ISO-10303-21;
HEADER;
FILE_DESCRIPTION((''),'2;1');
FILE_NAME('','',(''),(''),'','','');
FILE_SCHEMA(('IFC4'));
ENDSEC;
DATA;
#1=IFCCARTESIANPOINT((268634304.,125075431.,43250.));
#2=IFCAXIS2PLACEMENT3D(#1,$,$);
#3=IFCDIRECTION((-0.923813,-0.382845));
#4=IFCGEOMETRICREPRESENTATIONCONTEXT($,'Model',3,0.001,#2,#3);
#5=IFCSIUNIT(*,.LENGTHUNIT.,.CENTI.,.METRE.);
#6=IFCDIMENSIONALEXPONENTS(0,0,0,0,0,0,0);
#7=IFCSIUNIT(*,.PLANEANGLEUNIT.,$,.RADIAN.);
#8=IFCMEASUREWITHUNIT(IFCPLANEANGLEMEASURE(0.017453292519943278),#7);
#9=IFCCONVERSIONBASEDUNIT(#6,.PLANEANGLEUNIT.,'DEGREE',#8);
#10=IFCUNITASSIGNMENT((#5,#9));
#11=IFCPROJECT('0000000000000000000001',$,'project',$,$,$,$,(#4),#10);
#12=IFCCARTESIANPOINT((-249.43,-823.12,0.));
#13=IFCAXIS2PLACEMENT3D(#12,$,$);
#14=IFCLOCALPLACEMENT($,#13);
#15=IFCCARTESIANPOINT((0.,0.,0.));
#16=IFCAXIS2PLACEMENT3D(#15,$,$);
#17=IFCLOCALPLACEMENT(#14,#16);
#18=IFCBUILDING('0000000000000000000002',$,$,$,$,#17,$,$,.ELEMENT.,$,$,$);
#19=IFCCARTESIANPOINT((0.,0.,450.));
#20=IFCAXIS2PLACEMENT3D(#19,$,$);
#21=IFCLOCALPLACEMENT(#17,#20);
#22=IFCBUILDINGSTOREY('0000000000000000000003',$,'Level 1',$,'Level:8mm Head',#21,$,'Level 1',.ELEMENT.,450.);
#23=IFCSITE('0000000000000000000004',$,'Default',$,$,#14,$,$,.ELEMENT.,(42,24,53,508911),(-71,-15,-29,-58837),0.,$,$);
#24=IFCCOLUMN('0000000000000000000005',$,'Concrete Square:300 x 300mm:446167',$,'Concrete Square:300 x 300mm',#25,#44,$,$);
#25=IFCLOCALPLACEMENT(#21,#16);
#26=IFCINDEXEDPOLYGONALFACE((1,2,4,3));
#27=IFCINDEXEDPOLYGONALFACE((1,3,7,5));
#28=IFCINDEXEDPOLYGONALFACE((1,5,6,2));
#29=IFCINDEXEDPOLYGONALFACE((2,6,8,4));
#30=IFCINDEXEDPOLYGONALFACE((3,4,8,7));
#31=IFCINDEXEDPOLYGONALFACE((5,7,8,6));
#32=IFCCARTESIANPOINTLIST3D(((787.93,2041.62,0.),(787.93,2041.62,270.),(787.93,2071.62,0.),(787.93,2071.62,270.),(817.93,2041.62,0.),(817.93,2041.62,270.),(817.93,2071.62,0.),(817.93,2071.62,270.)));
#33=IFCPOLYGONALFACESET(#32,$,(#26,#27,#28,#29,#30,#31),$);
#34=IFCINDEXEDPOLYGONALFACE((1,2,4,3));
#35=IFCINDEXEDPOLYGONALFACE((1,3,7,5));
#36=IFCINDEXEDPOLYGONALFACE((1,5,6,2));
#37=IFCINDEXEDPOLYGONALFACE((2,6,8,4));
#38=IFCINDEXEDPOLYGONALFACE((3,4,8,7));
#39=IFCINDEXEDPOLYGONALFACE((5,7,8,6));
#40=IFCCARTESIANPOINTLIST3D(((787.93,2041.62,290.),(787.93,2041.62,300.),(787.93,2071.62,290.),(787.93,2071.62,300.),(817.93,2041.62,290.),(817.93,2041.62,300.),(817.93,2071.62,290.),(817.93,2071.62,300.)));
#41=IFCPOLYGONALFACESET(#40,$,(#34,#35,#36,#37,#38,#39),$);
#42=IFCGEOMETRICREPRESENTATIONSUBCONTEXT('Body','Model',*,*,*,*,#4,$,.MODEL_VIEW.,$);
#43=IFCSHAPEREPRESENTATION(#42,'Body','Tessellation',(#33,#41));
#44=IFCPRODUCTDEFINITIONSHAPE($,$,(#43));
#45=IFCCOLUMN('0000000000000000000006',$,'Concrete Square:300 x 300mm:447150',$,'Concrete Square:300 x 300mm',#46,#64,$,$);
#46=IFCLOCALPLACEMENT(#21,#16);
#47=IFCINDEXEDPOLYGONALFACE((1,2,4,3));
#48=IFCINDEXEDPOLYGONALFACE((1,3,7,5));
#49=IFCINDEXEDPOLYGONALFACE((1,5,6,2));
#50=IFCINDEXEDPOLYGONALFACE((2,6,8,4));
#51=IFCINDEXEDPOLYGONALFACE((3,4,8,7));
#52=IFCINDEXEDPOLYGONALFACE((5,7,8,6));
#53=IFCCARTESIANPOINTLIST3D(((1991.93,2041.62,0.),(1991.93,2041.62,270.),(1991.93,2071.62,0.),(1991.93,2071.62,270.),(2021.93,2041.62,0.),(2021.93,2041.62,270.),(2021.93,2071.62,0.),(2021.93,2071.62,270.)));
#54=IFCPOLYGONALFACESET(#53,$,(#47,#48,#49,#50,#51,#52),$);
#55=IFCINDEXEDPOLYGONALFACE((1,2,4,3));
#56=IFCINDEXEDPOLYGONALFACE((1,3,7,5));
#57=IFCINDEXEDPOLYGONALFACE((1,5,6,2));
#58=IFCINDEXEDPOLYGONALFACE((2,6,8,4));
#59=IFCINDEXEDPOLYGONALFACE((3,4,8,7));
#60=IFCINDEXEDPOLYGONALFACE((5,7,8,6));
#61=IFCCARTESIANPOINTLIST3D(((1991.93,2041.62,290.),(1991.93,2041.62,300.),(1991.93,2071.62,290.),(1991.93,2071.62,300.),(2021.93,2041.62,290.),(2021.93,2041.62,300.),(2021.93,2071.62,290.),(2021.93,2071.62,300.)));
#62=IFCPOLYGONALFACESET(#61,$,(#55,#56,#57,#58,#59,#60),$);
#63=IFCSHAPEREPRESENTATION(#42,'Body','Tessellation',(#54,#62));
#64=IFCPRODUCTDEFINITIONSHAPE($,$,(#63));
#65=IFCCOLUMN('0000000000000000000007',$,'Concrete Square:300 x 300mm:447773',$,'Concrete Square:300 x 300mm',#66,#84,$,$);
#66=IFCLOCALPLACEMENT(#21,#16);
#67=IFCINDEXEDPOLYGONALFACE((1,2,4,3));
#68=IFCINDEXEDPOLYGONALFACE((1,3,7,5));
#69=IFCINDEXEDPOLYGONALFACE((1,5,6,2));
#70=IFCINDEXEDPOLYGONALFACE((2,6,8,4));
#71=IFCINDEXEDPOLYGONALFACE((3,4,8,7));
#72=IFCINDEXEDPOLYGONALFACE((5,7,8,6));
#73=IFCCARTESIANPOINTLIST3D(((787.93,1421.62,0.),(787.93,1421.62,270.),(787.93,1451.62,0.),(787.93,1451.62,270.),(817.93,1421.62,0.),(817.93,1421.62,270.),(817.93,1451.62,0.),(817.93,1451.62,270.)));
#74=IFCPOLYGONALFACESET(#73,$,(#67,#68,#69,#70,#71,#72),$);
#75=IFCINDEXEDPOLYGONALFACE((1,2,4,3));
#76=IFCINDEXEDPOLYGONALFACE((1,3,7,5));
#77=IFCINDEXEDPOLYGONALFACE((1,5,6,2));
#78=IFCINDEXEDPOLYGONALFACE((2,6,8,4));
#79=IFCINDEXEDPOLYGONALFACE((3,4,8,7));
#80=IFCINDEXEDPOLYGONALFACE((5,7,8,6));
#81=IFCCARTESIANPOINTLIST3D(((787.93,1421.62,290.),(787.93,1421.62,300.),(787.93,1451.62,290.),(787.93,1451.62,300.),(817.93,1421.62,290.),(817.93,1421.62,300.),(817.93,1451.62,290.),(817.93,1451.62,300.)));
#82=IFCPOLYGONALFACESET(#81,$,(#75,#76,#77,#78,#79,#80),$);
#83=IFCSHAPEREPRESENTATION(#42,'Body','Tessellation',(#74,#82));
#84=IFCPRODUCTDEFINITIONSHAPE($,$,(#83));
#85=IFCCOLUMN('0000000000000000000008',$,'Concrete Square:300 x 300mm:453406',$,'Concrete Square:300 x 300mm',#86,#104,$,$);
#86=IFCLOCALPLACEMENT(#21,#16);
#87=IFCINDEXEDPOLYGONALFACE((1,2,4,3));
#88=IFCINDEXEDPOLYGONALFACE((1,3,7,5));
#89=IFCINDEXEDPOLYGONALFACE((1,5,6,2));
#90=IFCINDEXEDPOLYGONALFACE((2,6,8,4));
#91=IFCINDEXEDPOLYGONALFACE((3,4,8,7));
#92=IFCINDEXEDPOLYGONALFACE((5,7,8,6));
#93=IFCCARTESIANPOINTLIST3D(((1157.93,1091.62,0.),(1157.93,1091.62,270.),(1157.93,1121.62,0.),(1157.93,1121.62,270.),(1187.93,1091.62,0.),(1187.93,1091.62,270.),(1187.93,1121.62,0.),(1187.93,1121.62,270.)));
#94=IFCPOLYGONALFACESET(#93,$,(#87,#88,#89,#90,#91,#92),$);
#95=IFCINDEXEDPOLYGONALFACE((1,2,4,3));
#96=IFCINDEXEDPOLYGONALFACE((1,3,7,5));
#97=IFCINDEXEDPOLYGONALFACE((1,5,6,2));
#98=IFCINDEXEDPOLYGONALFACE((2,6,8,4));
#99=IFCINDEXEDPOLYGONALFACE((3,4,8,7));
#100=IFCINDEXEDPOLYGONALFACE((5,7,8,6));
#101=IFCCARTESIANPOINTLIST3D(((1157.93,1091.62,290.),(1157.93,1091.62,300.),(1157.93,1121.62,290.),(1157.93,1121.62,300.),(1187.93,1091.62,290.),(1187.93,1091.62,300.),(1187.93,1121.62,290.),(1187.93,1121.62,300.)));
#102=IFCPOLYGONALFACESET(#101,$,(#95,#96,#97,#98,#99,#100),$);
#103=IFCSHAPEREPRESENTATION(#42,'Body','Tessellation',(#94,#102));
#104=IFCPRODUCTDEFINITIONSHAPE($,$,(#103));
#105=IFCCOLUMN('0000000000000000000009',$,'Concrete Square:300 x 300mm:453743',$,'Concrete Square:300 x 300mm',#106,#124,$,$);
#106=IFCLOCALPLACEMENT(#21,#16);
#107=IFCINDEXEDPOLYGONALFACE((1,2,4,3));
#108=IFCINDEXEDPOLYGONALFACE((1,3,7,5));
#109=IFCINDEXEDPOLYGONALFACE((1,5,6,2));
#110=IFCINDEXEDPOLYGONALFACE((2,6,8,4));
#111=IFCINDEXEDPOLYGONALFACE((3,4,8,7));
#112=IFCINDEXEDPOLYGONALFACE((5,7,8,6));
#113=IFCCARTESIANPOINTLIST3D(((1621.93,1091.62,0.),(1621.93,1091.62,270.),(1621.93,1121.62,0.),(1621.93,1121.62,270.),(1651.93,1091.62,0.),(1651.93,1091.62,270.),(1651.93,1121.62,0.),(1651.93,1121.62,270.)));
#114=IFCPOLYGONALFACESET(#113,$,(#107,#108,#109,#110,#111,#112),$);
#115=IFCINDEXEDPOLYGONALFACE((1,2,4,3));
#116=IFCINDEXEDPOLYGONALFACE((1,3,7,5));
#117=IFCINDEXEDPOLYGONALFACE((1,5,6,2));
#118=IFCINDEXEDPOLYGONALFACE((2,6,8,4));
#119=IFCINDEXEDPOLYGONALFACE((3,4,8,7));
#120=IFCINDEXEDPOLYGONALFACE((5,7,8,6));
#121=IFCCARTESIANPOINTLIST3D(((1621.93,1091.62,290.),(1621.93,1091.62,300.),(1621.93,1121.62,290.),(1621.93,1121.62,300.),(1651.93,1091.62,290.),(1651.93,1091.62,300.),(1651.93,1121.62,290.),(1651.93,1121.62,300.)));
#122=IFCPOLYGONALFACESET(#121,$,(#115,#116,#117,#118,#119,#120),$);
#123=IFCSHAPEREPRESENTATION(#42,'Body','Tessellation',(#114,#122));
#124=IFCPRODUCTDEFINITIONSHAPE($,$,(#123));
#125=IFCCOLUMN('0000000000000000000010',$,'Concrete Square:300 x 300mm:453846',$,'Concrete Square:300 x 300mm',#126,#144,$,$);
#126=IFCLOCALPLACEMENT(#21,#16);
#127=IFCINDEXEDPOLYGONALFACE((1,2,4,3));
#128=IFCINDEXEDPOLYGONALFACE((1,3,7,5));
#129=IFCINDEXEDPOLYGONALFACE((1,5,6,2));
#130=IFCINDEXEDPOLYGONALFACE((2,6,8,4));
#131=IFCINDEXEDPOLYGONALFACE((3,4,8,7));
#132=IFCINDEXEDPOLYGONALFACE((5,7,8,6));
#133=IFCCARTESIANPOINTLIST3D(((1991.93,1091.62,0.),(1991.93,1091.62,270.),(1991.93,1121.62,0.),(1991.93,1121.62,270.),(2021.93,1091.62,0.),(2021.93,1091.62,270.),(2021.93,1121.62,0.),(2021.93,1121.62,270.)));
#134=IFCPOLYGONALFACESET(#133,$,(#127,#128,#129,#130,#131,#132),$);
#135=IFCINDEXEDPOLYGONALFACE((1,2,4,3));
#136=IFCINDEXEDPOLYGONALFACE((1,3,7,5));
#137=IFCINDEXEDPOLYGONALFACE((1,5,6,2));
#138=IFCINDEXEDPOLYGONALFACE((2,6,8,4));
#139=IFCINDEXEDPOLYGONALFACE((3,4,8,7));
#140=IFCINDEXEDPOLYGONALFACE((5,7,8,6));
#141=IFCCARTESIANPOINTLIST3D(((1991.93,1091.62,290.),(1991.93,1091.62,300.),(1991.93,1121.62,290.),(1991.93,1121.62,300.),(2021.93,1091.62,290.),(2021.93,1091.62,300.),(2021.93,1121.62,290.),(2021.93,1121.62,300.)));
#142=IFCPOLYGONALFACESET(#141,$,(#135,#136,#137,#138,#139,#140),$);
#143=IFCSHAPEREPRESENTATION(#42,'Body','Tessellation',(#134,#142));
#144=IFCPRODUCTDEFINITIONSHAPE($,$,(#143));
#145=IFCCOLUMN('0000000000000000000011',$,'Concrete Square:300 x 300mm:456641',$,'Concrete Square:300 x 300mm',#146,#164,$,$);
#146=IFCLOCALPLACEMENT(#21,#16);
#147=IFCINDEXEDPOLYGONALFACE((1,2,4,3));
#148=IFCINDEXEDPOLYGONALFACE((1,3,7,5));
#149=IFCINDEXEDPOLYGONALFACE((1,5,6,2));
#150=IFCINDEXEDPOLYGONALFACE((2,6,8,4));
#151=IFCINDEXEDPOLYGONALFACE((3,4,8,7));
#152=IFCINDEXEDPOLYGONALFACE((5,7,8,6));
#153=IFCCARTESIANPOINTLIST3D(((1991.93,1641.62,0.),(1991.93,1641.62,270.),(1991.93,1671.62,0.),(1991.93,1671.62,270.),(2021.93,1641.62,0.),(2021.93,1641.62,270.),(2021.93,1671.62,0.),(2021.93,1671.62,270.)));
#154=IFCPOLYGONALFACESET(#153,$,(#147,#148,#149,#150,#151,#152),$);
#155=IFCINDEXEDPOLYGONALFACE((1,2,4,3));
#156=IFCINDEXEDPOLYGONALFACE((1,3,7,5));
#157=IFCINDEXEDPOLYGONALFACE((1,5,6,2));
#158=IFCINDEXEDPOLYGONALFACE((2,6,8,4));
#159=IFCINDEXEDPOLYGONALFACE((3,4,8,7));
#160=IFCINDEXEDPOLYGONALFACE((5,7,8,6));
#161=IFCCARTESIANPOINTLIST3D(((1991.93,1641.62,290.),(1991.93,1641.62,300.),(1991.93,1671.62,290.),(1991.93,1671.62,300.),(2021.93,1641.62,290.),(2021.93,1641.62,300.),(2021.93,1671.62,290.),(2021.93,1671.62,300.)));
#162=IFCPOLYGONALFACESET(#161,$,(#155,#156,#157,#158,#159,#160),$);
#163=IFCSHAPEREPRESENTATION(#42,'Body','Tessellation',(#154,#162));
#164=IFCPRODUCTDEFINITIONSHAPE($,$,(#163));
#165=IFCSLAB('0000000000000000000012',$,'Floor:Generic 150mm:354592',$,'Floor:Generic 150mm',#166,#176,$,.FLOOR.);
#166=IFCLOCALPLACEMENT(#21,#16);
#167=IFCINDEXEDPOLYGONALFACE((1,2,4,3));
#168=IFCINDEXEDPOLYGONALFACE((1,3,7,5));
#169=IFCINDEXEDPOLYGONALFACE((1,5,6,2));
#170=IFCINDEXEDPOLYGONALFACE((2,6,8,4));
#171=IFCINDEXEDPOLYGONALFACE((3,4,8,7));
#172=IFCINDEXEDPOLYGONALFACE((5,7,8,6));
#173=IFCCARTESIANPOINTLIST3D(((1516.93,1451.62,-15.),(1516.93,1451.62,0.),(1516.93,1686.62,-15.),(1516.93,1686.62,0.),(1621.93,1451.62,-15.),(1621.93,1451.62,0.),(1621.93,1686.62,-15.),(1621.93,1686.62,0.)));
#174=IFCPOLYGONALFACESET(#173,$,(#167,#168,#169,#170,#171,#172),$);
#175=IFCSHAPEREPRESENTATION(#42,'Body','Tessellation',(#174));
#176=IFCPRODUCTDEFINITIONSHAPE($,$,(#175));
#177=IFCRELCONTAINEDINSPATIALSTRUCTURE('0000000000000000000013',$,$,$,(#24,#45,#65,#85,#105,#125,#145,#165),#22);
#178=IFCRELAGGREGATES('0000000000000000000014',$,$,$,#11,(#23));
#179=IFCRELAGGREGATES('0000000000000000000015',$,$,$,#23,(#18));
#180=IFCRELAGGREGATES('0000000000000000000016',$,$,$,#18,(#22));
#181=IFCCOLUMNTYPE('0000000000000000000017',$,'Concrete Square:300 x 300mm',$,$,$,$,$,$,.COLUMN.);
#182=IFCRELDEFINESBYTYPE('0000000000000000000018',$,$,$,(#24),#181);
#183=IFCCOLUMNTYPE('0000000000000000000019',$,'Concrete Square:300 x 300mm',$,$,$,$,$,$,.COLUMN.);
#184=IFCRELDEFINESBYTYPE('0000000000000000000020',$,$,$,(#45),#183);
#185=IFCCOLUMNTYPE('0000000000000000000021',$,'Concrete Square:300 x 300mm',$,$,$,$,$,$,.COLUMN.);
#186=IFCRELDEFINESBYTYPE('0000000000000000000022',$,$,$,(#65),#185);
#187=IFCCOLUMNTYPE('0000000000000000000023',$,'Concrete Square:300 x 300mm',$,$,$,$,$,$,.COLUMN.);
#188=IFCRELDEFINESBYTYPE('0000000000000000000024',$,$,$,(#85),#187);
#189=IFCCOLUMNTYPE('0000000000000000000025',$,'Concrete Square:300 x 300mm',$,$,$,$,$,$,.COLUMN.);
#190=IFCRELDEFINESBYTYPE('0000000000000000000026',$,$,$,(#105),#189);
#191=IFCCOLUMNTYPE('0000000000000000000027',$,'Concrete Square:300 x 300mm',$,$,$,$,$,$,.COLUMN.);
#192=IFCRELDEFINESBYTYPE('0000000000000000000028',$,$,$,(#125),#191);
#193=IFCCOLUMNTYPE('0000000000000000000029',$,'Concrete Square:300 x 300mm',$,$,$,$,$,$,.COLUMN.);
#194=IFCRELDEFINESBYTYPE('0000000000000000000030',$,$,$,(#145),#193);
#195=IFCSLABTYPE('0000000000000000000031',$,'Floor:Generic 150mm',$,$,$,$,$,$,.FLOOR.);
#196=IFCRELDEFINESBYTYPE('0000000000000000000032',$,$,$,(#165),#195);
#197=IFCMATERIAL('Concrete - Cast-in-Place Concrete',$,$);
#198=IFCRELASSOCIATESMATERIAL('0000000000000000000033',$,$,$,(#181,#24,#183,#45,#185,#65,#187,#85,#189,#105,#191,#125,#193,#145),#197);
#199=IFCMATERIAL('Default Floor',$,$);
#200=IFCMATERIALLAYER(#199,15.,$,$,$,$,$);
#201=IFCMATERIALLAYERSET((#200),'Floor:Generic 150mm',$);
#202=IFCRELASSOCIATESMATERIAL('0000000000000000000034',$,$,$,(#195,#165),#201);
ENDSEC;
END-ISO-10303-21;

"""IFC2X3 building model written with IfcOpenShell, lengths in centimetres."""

from ifc_helpers import new_model, entity, si_unit, converted_unit, direction, frame, frame_2d, origin, origin_2d_with_axis, place, context, subcontext, project, spatial, rectangle, extrude, source, transform, mapped, material, layer, layer_set, layer_usage, type_object, type_shapes, element, save


model = new_model("IFC2X3")

# Units and contexts
model_context = context("Model", 3, precision=0.001, world=frame((268634304.0, 125075431.0, 43250.0)), true_north=direction((-0.923813, -0.382845)))
body_context = subcontext(model_context, "Body", "Model", "MODEL_VIEW")
ifc_project = project(units=[si_unit("LENGTHUNIT", "METRE", prefix="CENTI"), converted_unit("PLANEANGLEUNIT", "DEGREE", entity("IfcPlaneAngleMeasure", 0.017453292519943278), si_unit("PLANEANGLEUNIT", "RADIAN"), dimensions=[0, 0, 0, 0, 0, 0, 0])], contexts=[model_context])

# Site, building, storey
site_placement = place(None, frame((-249.43, -823.12, 0.0)))
site = spatial("IfcSite", under=ifc_project, at=site_placement, Name="Default", CompositionType="ELEMENT", RefLatitude=(42, 24, 53, 508911), RefLongitude=(-71, -15, -29, -58837), RefElevation=0.0)
building_placement = place(site_placement, origin())
building = spatial("IfcBuilding", under=site, at=building_placement, CompositionType="ELEMENT")
storey_placement = place(building_placement, frame((0.0, 0.0, 450.0)))
storey = spatial("IfcBuildingStorey", under=building, at=storey_placement, Name="Level 1", ObjectType="Level:8mm Head", LongName="Level 1", CompositionType="ELEMENT", Elevation=450.0)

# Columns
ifc_material_1 = material(Name="Concrete - Cast-in-Place Concrete")
column_type_1 = type_object("IfcColumnType", Name="Concrete Square:300 x 300mm", PredefinedType="COLUMN", material=ifc_material_1)
shared_shape_1 = source(origin(), body_context, "Body", "SweptSolid", [
    extrude(rectangle(XDim=30.0, YDim=30.0, at=frame_2d((0.0, 0.0), x_axis=(1.0, 0.0))), frame((802.93, 2056.62, 450.0), z_axis=(0.0, 0.0, 1.0), x_axis=(-1.0, 0.0, 0.0)), (0.0, 0.0, 1.0), 270.0),
    extrude(rectangle(XDim=30.0, YDim=30.0, at=frame_2d((0.0, 0.0), x_axis=(1.0, 0.0))), frame((802.93, 2056.62, 740.0), z_axis=(0.0, 0.0, 1.0), x_axis=(-1.0, 0.0, 0.0)), (0.0, 0.0, 1.0), 10.0),
])
type_shapes(column_type_1, [shared_shape_1])
column_1_placement = place(storey_placement, frame((0.0, 0.0, -450.0)))
element("IfcColumn", 1, at=column_1_placement, inside=storey, type_object=column_type_1, material=ifc_material_1, Name="Concrete Square:300 x 300mm:446167", ObjectType="Concrete Square:300 x 300mm", context=body_context, shape_type="MappedRepresentation", body=[
    mapped(shared_shape_1, transform((0.0, 0.0, 0.0), scale=1.0)),
])
column_type_2 = type_object("IfcColumnType", Name="Concrete Square:300 x 300mm", PredefinedType="COLUMN", material=ifc_material_1)
shared_shape_2 = source(origin(), body_context, "Body", "SweptSolid", [
    extrude(rectangle(XDim=30.0, YDim=30.0, at=origin_2d_with_axis()), frame((2006.93, 2056.62, 450.0), z_axis=(0.0, 0.0, 1.0), x_axis=(-1.0, 0.0, 0.0)), (0.0, 0.0, 1.0), 270.0),
    extrude(rectangle(XDim=30.0, YDim=30.0, at=origin_2d_with_axis()), frame((2006.93, 2056.62, 740.0), z_axis=(0.0, 0.0, 1.0), x_axis=(-1.0, 0.0, 0.0)), (0.0, 0.0, 1.0), 10.0),
])
type_shapes(column_type_2, [shared_shape_2])
column_2_placement = place(storey_placement, frame((0.0, 0.0, -450.0)))
element("IfcColumn", 2, at=column_2_placement, inside=storey, type_object=column_type_2, material=ifc_material_1, Name="Concrete Square:300 x 300mm:447150", ObjectType="Concrete Square:300 x 300mm", context=body_context, shape_type="MappedRepresentation", body=[
    mapped(shared_shape_2, transform((0.0, 0.0, 0.0), scale=1.0)),
])
column_type_3 = type_object("IfcColumnType", Name="Concrete Square:300 x 300mm", PredefinedType="COLUMN", material=ifc_material_1)
shared_shape_3 = source(origin(), body_context, "Body", "SweptSolid", [
    extrude(rectangle(XDim=30.0, YDim=30.0, at=frame_2d((0.0, 0.0), x_axis=(1.0, 0.0))), frame((802.93, 1436.62, 450.0), z_axis=(0.0, 0.0, 1.0), x_axis=(-1.0, 0.0, 0.0)), (0.0, 0.0, 1.0), 270.0),
    extrude(rectangle(XDim=30.0, YDim=30.0, at=frame_2d((0.0, 0.0), x_axis=(1.0, 0.0))), frame((802.93, 1436.62, 740.0), z_axis=(0.0, 0.0, 1.0), x_axis=(-1.0, 0.0, 0.0)), (0.0, 0.0, 1.0), 10.0),
])
type_shapes(column_type_3, [shared_shape_3])
column_3_placement = place(storey_placement, frame((0.0, 0.0, -450.0)))
element("IfcColumn", 3, at=column_3_placement, inside=storey, type_object=column_type_3, material=ifc_material_1, Name="Concrete Square:300 x 300mm:447773", ObjectType="Concrete Square:300 x 300mm", context=body_context, shape_type="MappedRepresentation", body=[
    mapped(shared_shape_3, transform((0.0, 0.0, 0.0), scale=1.0)),
])
column_type_4 = type_object("IfcColumnType", Name="Concrete Square:300 x 300mm", PredefinedType="COLUMN", material=ifc_material_1)
shared_shape_4 = source(origin(), body_context, "Body", "SweptSolid", [
    extrude(rectangle(XDim=30.0, YDim=30.0, at=frame_2d((0.0, 0.0), x_axis=(1.0, 0.0))), frame((1172.93, 1106.62, 450.0), z_axis=(0.0, 0.0, 1.0), x_axis=(-1.0, 0.0, 0.0)), (0.0, 0.0, 1.0), 270.0),
    extrude(rectangle(XDim=30.0, YDim=30.0, at=origin_2d_with_axis()), frame((1172.93, 1106.62, 740.0), z_axis=(0.0, 0.0, 1.0), x_axis=(-1.0, 0.0, 0.0)), (0.0, 0.0, 1.0), 10.0),
])
type_shapes(column_type_4, [shared_shape_4])
column_4_placement = place(storey_placement, frame((0.0, 0.0, -450.0)))
element("IfcColumn", 4, at=column_4_placement, inside=storey, type_object=column_type_4, material=ifc_material_1, Name="Concrete Square:300 x 300mm:453406", ObjectType="Concrete Square:300 x 300mm", context=body_context, shape_type="MappedRepresentation", body=[
    mapped(shared_shape_4, transform((0.0, 0.0, 0.0), scale=1.0)),
])
column_type_5 = type_object("IfcColumnType", Name="Concrete Square:300 x 300mm", PredefinedType="COLUMN", material=ifc_material_1)
shared_shape_5 = source(origin(), body_context, "Body", "SweptSolid", [
    extrude(rectangle(XDim=30.0, YDim=30.0, at=frame_2d((0.0, 0.0), x_axis=(1.0, 0.0))), frame((1636.93, 1106.62, 450.0), z_axis=(0.0, 0.0, 1.0), x_axis=(-1.0, 0.0, 0.0)), (0.0, 0.0, 1.0), 270.0),
    extrude(rectangle(XDim=30.0, YDim=30.0, at=origin_2d_with_axis()), frame((1636.93, 1106.62, 740.0), z_axis=(0.0, 0.0, 1.0), x_axis=(-1.0, 0.0, 0.0)), (0.0, 0.0, 1.0), 10.0),
])
type_shapes(column_type_5, [shared_shape_5])
column_5_placement = place(storey_placement, frame((0.0, 0.0, -450.0)))
element("IfcColumn", 5, at=column_5_placement, inside=storey, type_object=column_type_5, material=ifc_material_1, Name="Concrete Square:300 x 300mm:453743", ObjectType="Concrete Square:300 x 300mm", context=body_context, shape_type="MappedRepresentation", body=[
    mapped(shared_shape_5, transform((0.0, 0.0, 0.0), scale=1.0)),
])
column_type_6 = type_object("IfcColumnType", Name="Concrete Square:300 x 300mm", PredefinedType="COLUMN", material=ifc_material_1)
shared_shape_6 = source(origin(), body_context, "Body", "SweptSolid", [
    extrude(rectangle(XDim=30.0, YDim=30.0, at=frame_2d((0.0, 0.0), x_axis=(1.0, 0.0))), frame((2006.93, 1106.62, 450.0), z_axis=(0.0, 0.0, 1.0), x_axis=(-1.0, 0.0, 0.0)), (0.0, 0.0, 1.0), 270.0),
    extrude(rectangle(XDim=30.0, YDim=30.0, at=origin_2d_with_axis()), frame((2006.93, 1106.62, 740.0), z_axis=(0.0, 0.0, 1.0), x_axis=(-1.0, 0.0, 0.0)), (0.0, 0.0, 1.0), 10.0),
])
type_shapes(column_type_6, [shared_shape_6])
column_6_placement = place(storey_placement, frame((0.0, 0.0, -450.0)))
element("IfcColumn", 6, at=column_6_placement, inside=storey, type_object=column_type_6, material=ifc_material_1, Name="Concrete Square:300 x 300mm:453846", ObjectType="Concrete Square:300 x 300mm", context=body_context, shape_type="MappedRepresentation", body=[
    mapped(shared_shape_6, transform((0.0, 0.0, 0.0), scale=1.0)),
])
column_type_7 = type_object("IfcColumnType", Name="Concrete Square:300 x 300mm", PredefinedType="COLUMN", material=ifc_material_1)
shared_shape_7 = source(origin(), body_context, "Body", "SweptSolid", [
    extrude(rectangle(XDim=30.0, YDim=30.0, at=frame_2d((0.0, 0.0), x_axis=(1.0, 0.0))), frame((2006.93, 1656.62, 450.0), z_axis=(0.0, 0.0, 1.0), x_axis=(-1.0, 0.0, 0.0)), (0.0, 0.0, 1.0), 270.0),
    extrude(rectangle(XDim=30.0, YDim=30.0, at=origin_2d_with_axis()), frame((2006.93, 1656.62, 740.0), z_axis=(0.0, 0.0, 1.0), x_axis=(-1.0, 0.0, 0.0)), (0.0, 0.0, 1.0), 10.0),
])
type_shapes(column_type_7, [shared_shape_7])
column_7_placement = place(storey_placement, frame((0.0, 0.0, -450.0)))
element("IfcColumn", 7, at=column_7_placement, inside=storey, type_object=column_type_7, material=ifc_material_1, Name="Concrete Square:300 x 300mm:456641", ObjectType="Concrete Square:300 x 300mm", context=body_context, shape_type="MappedRepresentation", body=[
    mapped(shared_shape_7, transform((0.0, 0.0, 0.0), scale=1.0)),
])

# Slab
ifc_material_2 = material(Name="Default Floor")
ifc_layer_1 = layer(ifc_material_2, 15.0)
ifc_layer_set_1 = layer_set([ifc_layer_1], Name="Floor:Generic 150mm")
ifc_layer_usage_1 = layer_usage(ifc_layer_set_1, "AXIS3", "POSITIVE", 0.0)
slab_type_1 = type_object("IfcSlabType", Name="Floor:Generic 150mm", PredefinedType="FLOOR", material=ifc_layer_set_1)
slab_1_placement = place(storey_placement, origin())
element("IfcSlab", 8, at=slab_1_placement, inside=storey, type_object=slab_type_1, material=ifc_layer_usage_1, Name="Floor:Generic 150mm:354592", ObjectType="Floor:Generic 150mm", PredefinedType="FLOOR", context=body_context, shape_type="SweptSolid", body=[
    extrude(rectangle(XDim=235.0, YDim=105.0, at=origin_2d_with_axis()), frame((1569.43, 1569.12, 0.0), z_axis=(0.0, 0.0, -1.0), x_axis=(0.0, 1.0, 0.0)), (0.0, 0.0, 1.0), 15.0),
])

save(model, "model.ifc")
